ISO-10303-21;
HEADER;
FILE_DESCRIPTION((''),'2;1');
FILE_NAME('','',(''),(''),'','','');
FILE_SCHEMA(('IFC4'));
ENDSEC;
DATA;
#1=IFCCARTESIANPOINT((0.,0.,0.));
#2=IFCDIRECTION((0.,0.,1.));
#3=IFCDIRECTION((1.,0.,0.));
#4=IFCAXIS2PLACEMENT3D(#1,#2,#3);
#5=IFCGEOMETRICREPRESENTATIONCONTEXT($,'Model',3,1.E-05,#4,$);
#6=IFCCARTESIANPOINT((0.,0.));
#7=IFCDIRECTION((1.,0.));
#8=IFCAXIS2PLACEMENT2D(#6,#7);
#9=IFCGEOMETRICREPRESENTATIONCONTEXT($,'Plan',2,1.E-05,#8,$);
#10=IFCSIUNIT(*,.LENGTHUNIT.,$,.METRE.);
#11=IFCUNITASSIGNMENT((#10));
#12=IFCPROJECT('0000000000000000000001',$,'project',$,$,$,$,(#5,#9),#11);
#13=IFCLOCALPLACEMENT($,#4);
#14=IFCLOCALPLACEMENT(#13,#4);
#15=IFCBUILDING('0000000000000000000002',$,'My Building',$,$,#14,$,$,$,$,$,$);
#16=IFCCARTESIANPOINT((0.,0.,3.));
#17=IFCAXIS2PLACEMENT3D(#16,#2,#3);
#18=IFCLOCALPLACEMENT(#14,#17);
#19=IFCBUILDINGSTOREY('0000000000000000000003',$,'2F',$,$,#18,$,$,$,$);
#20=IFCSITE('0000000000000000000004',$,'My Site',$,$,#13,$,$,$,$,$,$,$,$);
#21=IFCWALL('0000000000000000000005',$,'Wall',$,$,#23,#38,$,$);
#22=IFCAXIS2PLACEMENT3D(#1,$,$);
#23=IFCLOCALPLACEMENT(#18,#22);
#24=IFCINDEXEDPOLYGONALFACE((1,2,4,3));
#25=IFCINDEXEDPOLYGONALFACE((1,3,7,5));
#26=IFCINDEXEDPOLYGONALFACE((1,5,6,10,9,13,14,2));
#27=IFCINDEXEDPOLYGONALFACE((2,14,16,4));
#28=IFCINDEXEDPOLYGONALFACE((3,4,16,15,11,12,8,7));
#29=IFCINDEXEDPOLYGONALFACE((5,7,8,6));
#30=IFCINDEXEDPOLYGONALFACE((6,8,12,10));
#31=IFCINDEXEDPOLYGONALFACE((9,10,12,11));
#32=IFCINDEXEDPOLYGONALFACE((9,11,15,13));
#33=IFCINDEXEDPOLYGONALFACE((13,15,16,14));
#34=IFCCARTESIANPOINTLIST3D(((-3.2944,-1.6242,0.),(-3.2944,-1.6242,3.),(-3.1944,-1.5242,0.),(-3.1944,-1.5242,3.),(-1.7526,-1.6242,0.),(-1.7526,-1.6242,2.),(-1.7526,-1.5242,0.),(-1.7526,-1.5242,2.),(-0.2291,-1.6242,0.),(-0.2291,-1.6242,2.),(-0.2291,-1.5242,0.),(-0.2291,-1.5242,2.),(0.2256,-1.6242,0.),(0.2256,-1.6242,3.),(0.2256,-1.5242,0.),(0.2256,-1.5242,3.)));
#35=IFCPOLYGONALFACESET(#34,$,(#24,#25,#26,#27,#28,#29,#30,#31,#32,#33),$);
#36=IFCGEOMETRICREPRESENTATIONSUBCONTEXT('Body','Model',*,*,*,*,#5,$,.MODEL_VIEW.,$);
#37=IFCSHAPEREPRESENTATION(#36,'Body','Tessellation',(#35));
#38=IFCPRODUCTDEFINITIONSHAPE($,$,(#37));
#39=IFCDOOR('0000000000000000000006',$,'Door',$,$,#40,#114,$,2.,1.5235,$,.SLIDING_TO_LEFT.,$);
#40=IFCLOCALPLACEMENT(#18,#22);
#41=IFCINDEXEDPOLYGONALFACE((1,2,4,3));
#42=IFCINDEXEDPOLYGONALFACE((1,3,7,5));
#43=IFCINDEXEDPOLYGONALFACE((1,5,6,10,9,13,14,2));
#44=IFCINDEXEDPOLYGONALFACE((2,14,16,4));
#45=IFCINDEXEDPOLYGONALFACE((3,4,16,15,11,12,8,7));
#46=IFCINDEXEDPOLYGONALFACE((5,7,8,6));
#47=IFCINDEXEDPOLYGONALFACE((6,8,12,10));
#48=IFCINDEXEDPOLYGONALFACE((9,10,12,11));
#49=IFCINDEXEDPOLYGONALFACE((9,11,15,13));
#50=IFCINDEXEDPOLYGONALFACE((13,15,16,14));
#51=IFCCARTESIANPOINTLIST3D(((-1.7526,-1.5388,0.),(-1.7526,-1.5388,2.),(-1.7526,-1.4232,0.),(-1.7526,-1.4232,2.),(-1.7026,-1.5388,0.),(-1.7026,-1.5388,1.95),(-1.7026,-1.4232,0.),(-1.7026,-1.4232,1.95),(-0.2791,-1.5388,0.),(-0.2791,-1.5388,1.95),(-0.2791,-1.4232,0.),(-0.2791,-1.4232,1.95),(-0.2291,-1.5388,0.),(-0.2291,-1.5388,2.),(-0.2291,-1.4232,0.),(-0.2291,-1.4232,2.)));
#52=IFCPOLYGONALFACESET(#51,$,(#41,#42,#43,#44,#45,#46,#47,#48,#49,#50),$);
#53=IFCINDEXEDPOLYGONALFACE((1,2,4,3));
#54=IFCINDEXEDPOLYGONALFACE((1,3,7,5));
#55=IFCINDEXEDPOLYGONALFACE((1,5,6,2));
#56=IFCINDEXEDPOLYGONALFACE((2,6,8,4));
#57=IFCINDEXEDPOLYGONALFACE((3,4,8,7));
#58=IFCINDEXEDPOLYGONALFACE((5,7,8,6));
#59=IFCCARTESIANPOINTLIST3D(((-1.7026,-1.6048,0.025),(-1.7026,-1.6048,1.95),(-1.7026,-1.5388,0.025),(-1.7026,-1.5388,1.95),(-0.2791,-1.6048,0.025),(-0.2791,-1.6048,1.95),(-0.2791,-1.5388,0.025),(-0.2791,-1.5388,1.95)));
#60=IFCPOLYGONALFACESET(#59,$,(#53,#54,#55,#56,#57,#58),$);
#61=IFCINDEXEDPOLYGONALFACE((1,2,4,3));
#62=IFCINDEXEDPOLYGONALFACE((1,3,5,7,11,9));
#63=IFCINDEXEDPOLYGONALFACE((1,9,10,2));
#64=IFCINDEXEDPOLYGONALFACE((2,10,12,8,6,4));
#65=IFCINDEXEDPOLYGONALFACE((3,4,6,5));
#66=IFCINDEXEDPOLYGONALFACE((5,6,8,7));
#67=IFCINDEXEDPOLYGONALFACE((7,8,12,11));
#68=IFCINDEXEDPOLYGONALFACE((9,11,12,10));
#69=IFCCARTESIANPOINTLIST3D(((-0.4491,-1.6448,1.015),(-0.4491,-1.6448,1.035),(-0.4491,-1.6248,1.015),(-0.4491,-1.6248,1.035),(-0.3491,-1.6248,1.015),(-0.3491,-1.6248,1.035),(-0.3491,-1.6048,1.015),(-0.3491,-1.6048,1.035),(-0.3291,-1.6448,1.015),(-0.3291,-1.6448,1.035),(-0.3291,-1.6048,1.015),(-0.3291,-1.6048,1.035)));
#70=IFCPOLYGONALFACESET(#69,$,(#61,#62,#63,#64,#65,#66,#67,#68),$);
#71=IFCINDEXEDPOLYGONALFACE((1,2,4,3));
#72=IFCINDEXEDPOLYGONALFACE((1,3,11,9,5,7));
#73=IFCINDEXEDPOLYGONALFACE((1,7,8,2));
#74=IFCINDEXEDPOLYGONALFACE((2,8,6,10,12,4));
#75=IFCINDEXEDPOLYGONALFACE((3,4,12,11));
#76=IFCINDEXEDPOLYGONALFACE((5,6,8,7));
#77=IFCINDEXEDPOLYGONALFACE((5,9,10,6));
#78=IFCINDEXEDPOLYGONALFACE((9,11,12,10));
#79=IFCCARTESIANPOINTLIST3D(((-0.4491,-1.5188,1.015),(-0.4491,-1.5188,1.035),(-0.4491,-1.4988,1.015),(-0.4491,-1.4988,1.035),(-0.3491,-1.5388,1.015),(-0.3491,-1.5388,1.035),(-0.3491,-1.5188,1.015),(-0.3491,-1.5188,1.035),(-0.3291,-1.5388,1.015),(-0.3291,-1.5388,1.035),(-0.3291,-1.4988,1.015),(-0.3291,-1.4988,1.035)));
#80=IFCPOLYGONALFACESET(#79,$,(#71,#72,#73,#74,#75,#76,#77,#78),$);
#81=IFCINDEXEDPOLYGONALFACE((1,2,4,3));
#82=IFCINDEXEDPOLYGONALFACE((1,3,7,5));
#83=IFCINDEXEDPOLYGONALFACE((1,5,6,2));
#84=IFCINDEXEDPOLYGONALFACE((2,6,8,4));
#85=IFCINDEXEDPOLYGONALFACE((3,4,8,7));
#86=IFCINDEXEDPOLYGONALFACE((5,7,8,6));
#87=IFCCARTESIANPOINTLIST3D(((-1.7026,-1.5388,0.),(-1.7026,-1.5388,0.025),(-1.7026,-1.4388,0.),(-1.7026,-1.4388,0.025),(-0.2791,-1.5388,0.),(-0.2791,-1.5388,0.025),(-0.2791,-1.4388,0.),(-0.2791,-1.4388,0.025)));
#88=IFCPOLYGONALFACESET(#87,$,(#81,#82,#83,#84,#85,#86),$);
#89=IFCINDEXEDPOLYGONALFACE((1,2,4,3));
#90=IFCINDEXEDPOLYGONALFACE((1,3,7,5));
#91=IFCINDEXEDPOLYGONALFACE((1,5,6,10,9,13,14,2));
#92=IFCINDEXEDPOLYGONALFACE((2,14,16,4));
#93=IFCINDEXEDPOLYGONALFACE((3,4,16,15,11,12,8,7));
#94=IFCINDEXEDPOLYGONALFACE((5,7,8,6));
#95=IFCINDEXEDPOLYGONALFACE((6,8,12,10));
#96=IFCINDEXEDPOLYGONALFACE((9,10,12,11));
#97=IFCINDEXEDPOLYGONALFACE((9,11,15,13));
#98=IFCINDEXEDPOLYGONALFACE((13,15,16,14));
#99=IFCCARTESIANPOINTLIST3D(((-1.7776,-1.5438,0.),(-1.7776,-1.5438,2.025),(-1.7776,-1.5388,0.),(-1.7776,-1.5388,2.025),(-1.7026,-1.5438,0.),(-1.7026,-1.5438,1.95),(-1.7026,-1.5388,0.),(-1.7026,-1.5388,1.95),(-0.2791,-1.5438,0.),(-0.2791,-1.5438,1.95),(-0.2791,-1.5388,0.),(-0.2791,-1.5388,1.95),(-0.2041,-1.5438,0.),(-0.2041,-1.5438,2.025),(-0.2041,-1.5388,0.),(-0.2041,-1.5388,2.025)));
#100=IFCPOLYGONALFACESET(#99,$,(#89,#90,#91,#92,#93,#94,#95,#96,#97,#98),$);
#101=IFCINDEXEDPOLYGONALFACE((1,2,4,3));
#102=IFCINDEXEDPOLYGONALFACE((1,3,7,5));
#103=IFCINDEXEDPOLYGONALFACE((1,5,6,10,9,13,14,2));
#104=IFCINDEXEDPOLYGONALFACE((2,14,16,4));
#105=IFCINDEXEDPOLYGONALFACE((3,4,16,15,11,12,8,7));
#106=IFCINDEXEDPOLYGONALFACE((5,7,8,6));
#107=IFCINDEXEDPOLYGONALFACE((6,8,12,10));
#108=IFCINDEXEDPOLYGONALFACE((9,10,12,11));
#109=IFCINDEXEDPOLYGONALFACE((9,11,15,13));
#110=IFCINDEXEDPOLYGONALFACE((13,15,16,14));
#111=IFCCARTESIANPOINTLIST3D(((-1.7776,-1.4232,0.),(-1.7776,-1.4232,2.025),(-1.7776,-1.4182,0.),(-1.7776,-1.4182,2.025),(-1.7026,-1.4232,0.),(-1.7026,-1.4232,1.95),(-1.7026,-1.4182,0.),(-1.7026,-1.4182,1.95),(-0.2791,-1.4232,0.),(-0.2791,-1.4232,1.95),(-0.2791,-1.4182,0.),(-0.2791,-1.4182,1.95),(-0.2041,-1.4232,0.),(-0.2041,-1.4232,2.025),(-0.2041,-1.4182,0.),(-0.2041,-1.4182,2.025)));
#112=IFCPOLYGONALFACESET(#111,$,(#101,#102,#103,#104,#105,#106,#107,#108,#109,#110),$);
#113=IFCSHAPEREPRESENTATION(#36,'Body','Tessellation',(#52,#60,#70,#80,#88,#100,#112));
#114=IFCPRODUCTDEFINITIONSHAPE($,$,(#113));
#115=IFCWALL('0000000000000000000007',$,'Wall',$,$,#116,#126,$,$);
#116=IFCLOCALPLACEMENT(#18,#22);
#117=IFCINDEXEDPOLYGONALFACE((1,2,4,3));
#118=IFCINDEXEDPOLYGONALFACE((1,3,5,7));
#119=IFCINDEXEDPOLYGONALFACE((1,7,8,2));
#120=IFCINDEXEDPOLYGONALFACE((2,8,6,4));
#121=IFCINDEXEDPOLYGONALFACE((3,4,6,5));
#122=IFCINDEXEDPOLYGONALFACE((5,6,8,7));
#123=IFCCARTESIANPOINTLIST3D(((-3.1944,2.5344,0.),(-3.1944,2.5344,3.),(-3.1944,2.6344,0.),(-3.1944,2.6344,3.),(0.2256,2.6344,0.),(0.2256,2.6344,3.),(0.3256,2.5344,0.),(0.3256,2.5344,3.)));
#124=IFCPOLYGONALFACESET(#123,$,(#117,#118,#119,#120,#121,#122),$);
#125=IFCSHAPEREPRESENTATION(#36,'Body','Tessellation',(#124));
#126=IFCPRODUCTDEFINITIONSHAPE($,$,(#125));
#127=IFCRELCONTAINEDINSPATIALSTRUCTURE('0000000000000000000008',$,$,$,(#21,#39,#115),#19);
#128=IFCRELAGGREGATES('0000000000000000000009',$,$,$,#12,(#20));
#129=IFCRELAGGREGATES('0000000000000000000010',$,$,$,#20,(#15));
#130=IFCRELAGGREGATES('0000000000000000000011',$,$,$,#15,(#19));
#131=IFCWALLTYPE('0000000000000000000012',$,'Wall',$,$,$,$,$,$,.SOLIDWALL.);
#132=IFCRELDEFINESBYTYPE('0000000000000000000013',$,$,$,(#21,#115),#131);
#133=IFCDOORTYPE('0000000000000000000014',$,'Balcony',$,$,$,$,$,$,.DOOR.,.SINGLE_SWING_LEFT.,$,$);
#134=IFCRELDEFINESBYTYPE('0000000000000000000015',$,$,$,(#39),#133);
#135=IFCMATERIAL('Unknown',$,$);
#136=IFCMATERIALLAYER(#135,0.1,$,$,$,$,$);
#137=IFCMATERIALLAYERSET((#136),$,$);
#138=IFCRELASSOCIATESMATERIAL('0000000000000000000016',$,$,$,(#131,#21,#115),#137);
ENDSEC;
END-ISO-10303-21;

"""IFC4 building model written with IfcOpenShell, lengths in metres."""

from ifc_helpers import new_model, entity, si_unit, frame, origin_with_axes, origin_2d_with_axis, place, context, subcontext, project, spatial, line, indexed_curve, outline, extrude, shape, source, transform, mapped, material, layer, layer_set, layer_usage, type_object, type_shapes, element, fill, save


model = new_model("IFC4")

# Units and contexts
model_context = context("Model", 3, precision=1e-05, world=origin_with_axes())
plan_context = context("Plan", 2, precision=1e-05, world=origin_2d_with_axis())
body_context_1 = subcontext(model_context, "Body", "Model", "MODEL_VIEW")
body_context_2 = subcontext(plan_context, "Body", "Plan", "PLAN_VIEW")
ifc_project = project(units=[si_unit("LENGTHUNIT", "METRE")], contexts=[model_context, plan_context])

# Site, building, storey
site_placement = place(None, origin_with_axes())
site = spatial("IfcSite", under=ifc_project, at=site_placement, Name="My Site")
building_placement = place(site_placement, origin_with_axes())
building = spatial("IfcBuilding", under=site, at=building_placement, Name="My Building")
storey_placement = place(building_placement, frame((0.0, 0.0, 3.0), z_axis=(0.0, 0.0, 1.0), x_axis=(1.0, 0.0, 0.0)))
storey = spatial("IfcBuildingStorey", under=building, at=storey_placement, Name="2F")

# Shared definitions
ifc_material = material(Name="Unknown")
ifc_layer = layer(ifc_material, 0.1)
ifc_layer_set = layer_set([ifc_layer])
wall_type = type_object("IfcWallType", Name="Wall", PredefinedType="SOLIDWALL", material=ifc_layer_set)

# Wall, opening, door
ifc_layer_usage_1 = layer_usage(ifc_layer_set, "AXIS2", "POSITIVE", 0.0)
wall_1_placement = place(storey_placement, frame((-3.2944, -1.6242, 0.0), z_axis=(0.0, 0.0, 1.0), x_axis=(1.0, 0.0, 0.0)))
wall_1 = element("IfcWall", 1, at=wall_1_placement, inside=storey, type_object=wall_type, material=ifc_layer_usage_1, Name="Wall", context=body_context_1, shape_type="SweptSolid", body=[
    extrude(outline(indexed_curve([(0.0, 0.0), (0.1, 0.1), (3.52, 0.1), (3.52, 0.0)], segments=[line(1, 2, 3, 4, 1)])), origin_with_axes(), (0.0, 0.0, 1.0), 3.0),
])
shared_shape_1 = source(origin_with_axes(), body_context_1, "Body", "SweptSolid", [
    extrude(outline(indexed_curve([(0.0, 0.0), (1.5235, 0.0), (1.5235, 2.0), (0.0, 2.0)], segments=[line(1, 2, 3, 4, 1)])), frame((0.0, -0.6, 0.0), z_axis=(0.0, -1.0, 0.0), x_axis=(1.0, 0.0, 0.0)), (0.0, 0.0, -1.0), 1.2),
])
opening_1_placement = place(wall_1_placement, frame((1.5418, 0.0855, 0.0), z_axis=(0.0, 0.0, 1.0), x_axis=(1.0, -0.000001, 0.0)))
opening_1 = element("IfcOpeningElement", 2, at=opening_1_placement, cuts=wall_1, PredefinedType="OPENING", context=body_context_1, shape_type="MappedRepresentation", body=[
    mapped(shared_shape_1, transform((0.0, 0.0, 0.0), x_axis=(1.0, 0.0, 0.0), y_axis=(0.0, 1.0, 0.0), z_axis=(0.0, 0.0, 1.0), scale=1.0)),
])
door_type_1 = type_object("IfcDoorType", Name="Balcony", OperationType="SINGLE_SWING_LEFT", PredefinedType="DOOR")
shared_shape_2 = source(origin_with_axes(), body_context_1, "Body", "SweptSolid", [
    extrude(outline(indexed_curve([(0.0, 0.0), (0.0, 2.0), (1.5235, 2.0), (1.5235, 0.0), (1.4735, 0.0), (1.4735, 1.95), (0.05, 1.95), (0.05, 0.0)], segments=[line(1, 2, 3, 4, 5, 6, 7, 8, 1)])), frame((0.0, 0.0, 0.0), z_axis=(0.0, -1.0, 0.0), x_axis=(1.0, 0.0, 0.0)), (0.0, 0.0, -1.0), 0.1156),
    extrude(outline(indexed_curve([(0.0, 0.0), (1.4235, 0.0), (1.4235, 0.0661), (0.0, 0.0661)], segments=[line(1, 2, 3, 4, 1)])), frame((0.05, -0.0661, 0.025), z_axis=(0.0, 0.0, 1.0), x_axis=(1.0, 0.0, 0.0)), (0.0, 0.0, 1.0), 1.925),
    extrude(outline(indexed_curve([(0.0, 0.0), (0.0, -0.04), (-0.12, -0.04), (-0.12, -0.02), (-0.02, -0.02), (-0.02, 0.0)], segments=[line(1, 2, 3, 4, 5, 6, 1)])), frame((1.4235, -0.0661, 1.015), z_axis=(0.0, 0.0, 1.0), x_axis=(1.0, 0.0, 0.0)), (0.0, 0.0, 1.0), 0.02),
    extrude(outline(indexed_curve([(0.0, 0.0), (0.0, 0.04), (-0.12, 0.04), (-0.12, 0.02), (-0.02, 0.02), (-0.02, 0.0)], segments=[line(1, 2, 3, 4, 5, 6, 1)])), frame((1.4235, 0.0, 1.015), z_axis=(0.0, 0.0, 1.0), x_axis=(1.0, 0.0, 0.0)), (0.0, 0.0, 1.0), 0.02),
    extrude(outline(indexed_curve([(0.0, 0.0), (1.4235, 0.0), (1.4235, 0.1), (0.0, 0.1)], segments=[line(1, 2, 3, 4, 1)])), frame((0.05, 0.0, 0.0), z_axis=(0.0, 0.0, 1.0), x_axis=(1.0, 0.0, 0.0)), (0.0, 0.0, 1.0), 0.025),
    extrude(outline(indexed_curve([(0.0, 0.0), (0.0, 2.025), (1.5735, 2.025), (1.5735, 0.0), (1.4985, 0.0), (1.4985, 1.95), (0.075, 1.95), (0.075, 0.0)], segments=[line(1, 2, 3, 4, 5, 6, 7, 8, 1)])), frame((-0.025, -0.005, 0.0), z_axis=(0.0, -1.0, 0.0), x_axis=(1.0, 0.0, 0.0)), (0.0, 0.0, -1.0), 0.005),
    extrude(outline(indexed_curve([(0.0, 0.0), (0.0, 2.025), (1.5735, 2.025), (1.5735, 0.0), (1.4985, 0.0), (1.4985, 1.95), (0.075, 1.95), (0.075, 0.0)], segments=[line(1, 2, 3, 4, 5, 6, 7, 8, 1)])), frame((-0.025, 0.1156, 0.0), z_axis=(0.0, -1.0, 0.0), x_axis=(1.0, 0.0, 0.0)), (0.0, 0.0, -1.0), 0.005),
])
shared_shape_3 = source(origin_with_axes(), body_context_2, "Body", "Curve2D", [
    entity("IfcIndexedPolyCurve", entity("IfcCartesianPointList2D", [[0.0, 0.0], [0.05, 0.0], [0.05, 0.1156], [0.0, 0.1156]]), [entity("IfcLineIndex", [1, 2, 3, 4, 1])]),
    entity("IfcIndexedPolyCurve", entity("IfcCartesianPointList2D", [[1.5235, 0.0], [1.4735, 0.0], [1.4735, 0.1156], [1.5235, 0.1156]]), [entity("IfcLineIndex", [1, 2, 3, 4, 1])]),
    entity("IfcIndexedPolyCurve", entity("IfcCartesianPointList2D", [[-0.6617, -0.0661], [0.7617, -0.0661], [0.7617, 0.0], [-0.6617, 0.0]]), [entity("IfcLineIndex", [1, 2, 3, 4, 1])]),
])
type_shapes(door_type_1, [shared_shape_2, shared_shape_3])
door_1_placement = place(opening_1_placement, frame((0.0, 0.0, 0.0), z_axis=(0.0, 0.0, 1.0), x_axis=(1.0, 0.0, 0.0)))
door_1 = element("IfcDoor", 3, at=door_1_placement, inside=storey, type_object=door_type_1, Name="Door", OperationType="SLIDING_TO_LEFT", OverallHeight=2.0, OverallWidth=1.5235, shapes=[
    shape(body_context_1, "Body", "MappedRepresentation", [mapped(shared_shape_2, transform((0.0, 0.0, 0.0), x_axis=(1.0, 0.0, 0.0), y_axis=(0.0, 1.0, 0.0), z_axis=(0.0, 0.0, 1.0), scale=1.0))]),
    shape(body_context_2, "Body", "MappedRepresentation", [mapped(shared_shape_3, transform((0.0, 0.0, 0.0), x_axis=(1.0, 0.0, 0.0), y_axis=(0.0, 1.0, 0.0), z_axis=(0.0, 0.0, 1.0), scale=1.0))]),
])
fill(opening_1, door_1)

# Wall
ifc_layer_usage_2 = layer_usage(ifc_layer_set, "AXIS2", "POSITIVE", 0.0)
wall_2_placement = place(storey_placement, frame((-3.1944, 2.5344, 0.0), z_axis=(0.0, 0.0, 1.0), x_axis=(1.0, 0.0, 0.0)))
element("IfcWall", 4, at=wall_2_placement, inside=storey, type_object=wall_type, material=ifc_layer_usage_2, Name="Wall", context=body_context_1, shape_type="SweptSolid", body=[
    extrude(outline(indexed_curve([(0.0, 0.0), (0.0, 0.1), (3.42, 0.1), (3.52, 0.0)], segments=[line(1, 2, 3, 4, 1)])), origin_with_axes(), (0.0, 0.0, 1.0), 3.0),
])

save(model, "model.ifc")
